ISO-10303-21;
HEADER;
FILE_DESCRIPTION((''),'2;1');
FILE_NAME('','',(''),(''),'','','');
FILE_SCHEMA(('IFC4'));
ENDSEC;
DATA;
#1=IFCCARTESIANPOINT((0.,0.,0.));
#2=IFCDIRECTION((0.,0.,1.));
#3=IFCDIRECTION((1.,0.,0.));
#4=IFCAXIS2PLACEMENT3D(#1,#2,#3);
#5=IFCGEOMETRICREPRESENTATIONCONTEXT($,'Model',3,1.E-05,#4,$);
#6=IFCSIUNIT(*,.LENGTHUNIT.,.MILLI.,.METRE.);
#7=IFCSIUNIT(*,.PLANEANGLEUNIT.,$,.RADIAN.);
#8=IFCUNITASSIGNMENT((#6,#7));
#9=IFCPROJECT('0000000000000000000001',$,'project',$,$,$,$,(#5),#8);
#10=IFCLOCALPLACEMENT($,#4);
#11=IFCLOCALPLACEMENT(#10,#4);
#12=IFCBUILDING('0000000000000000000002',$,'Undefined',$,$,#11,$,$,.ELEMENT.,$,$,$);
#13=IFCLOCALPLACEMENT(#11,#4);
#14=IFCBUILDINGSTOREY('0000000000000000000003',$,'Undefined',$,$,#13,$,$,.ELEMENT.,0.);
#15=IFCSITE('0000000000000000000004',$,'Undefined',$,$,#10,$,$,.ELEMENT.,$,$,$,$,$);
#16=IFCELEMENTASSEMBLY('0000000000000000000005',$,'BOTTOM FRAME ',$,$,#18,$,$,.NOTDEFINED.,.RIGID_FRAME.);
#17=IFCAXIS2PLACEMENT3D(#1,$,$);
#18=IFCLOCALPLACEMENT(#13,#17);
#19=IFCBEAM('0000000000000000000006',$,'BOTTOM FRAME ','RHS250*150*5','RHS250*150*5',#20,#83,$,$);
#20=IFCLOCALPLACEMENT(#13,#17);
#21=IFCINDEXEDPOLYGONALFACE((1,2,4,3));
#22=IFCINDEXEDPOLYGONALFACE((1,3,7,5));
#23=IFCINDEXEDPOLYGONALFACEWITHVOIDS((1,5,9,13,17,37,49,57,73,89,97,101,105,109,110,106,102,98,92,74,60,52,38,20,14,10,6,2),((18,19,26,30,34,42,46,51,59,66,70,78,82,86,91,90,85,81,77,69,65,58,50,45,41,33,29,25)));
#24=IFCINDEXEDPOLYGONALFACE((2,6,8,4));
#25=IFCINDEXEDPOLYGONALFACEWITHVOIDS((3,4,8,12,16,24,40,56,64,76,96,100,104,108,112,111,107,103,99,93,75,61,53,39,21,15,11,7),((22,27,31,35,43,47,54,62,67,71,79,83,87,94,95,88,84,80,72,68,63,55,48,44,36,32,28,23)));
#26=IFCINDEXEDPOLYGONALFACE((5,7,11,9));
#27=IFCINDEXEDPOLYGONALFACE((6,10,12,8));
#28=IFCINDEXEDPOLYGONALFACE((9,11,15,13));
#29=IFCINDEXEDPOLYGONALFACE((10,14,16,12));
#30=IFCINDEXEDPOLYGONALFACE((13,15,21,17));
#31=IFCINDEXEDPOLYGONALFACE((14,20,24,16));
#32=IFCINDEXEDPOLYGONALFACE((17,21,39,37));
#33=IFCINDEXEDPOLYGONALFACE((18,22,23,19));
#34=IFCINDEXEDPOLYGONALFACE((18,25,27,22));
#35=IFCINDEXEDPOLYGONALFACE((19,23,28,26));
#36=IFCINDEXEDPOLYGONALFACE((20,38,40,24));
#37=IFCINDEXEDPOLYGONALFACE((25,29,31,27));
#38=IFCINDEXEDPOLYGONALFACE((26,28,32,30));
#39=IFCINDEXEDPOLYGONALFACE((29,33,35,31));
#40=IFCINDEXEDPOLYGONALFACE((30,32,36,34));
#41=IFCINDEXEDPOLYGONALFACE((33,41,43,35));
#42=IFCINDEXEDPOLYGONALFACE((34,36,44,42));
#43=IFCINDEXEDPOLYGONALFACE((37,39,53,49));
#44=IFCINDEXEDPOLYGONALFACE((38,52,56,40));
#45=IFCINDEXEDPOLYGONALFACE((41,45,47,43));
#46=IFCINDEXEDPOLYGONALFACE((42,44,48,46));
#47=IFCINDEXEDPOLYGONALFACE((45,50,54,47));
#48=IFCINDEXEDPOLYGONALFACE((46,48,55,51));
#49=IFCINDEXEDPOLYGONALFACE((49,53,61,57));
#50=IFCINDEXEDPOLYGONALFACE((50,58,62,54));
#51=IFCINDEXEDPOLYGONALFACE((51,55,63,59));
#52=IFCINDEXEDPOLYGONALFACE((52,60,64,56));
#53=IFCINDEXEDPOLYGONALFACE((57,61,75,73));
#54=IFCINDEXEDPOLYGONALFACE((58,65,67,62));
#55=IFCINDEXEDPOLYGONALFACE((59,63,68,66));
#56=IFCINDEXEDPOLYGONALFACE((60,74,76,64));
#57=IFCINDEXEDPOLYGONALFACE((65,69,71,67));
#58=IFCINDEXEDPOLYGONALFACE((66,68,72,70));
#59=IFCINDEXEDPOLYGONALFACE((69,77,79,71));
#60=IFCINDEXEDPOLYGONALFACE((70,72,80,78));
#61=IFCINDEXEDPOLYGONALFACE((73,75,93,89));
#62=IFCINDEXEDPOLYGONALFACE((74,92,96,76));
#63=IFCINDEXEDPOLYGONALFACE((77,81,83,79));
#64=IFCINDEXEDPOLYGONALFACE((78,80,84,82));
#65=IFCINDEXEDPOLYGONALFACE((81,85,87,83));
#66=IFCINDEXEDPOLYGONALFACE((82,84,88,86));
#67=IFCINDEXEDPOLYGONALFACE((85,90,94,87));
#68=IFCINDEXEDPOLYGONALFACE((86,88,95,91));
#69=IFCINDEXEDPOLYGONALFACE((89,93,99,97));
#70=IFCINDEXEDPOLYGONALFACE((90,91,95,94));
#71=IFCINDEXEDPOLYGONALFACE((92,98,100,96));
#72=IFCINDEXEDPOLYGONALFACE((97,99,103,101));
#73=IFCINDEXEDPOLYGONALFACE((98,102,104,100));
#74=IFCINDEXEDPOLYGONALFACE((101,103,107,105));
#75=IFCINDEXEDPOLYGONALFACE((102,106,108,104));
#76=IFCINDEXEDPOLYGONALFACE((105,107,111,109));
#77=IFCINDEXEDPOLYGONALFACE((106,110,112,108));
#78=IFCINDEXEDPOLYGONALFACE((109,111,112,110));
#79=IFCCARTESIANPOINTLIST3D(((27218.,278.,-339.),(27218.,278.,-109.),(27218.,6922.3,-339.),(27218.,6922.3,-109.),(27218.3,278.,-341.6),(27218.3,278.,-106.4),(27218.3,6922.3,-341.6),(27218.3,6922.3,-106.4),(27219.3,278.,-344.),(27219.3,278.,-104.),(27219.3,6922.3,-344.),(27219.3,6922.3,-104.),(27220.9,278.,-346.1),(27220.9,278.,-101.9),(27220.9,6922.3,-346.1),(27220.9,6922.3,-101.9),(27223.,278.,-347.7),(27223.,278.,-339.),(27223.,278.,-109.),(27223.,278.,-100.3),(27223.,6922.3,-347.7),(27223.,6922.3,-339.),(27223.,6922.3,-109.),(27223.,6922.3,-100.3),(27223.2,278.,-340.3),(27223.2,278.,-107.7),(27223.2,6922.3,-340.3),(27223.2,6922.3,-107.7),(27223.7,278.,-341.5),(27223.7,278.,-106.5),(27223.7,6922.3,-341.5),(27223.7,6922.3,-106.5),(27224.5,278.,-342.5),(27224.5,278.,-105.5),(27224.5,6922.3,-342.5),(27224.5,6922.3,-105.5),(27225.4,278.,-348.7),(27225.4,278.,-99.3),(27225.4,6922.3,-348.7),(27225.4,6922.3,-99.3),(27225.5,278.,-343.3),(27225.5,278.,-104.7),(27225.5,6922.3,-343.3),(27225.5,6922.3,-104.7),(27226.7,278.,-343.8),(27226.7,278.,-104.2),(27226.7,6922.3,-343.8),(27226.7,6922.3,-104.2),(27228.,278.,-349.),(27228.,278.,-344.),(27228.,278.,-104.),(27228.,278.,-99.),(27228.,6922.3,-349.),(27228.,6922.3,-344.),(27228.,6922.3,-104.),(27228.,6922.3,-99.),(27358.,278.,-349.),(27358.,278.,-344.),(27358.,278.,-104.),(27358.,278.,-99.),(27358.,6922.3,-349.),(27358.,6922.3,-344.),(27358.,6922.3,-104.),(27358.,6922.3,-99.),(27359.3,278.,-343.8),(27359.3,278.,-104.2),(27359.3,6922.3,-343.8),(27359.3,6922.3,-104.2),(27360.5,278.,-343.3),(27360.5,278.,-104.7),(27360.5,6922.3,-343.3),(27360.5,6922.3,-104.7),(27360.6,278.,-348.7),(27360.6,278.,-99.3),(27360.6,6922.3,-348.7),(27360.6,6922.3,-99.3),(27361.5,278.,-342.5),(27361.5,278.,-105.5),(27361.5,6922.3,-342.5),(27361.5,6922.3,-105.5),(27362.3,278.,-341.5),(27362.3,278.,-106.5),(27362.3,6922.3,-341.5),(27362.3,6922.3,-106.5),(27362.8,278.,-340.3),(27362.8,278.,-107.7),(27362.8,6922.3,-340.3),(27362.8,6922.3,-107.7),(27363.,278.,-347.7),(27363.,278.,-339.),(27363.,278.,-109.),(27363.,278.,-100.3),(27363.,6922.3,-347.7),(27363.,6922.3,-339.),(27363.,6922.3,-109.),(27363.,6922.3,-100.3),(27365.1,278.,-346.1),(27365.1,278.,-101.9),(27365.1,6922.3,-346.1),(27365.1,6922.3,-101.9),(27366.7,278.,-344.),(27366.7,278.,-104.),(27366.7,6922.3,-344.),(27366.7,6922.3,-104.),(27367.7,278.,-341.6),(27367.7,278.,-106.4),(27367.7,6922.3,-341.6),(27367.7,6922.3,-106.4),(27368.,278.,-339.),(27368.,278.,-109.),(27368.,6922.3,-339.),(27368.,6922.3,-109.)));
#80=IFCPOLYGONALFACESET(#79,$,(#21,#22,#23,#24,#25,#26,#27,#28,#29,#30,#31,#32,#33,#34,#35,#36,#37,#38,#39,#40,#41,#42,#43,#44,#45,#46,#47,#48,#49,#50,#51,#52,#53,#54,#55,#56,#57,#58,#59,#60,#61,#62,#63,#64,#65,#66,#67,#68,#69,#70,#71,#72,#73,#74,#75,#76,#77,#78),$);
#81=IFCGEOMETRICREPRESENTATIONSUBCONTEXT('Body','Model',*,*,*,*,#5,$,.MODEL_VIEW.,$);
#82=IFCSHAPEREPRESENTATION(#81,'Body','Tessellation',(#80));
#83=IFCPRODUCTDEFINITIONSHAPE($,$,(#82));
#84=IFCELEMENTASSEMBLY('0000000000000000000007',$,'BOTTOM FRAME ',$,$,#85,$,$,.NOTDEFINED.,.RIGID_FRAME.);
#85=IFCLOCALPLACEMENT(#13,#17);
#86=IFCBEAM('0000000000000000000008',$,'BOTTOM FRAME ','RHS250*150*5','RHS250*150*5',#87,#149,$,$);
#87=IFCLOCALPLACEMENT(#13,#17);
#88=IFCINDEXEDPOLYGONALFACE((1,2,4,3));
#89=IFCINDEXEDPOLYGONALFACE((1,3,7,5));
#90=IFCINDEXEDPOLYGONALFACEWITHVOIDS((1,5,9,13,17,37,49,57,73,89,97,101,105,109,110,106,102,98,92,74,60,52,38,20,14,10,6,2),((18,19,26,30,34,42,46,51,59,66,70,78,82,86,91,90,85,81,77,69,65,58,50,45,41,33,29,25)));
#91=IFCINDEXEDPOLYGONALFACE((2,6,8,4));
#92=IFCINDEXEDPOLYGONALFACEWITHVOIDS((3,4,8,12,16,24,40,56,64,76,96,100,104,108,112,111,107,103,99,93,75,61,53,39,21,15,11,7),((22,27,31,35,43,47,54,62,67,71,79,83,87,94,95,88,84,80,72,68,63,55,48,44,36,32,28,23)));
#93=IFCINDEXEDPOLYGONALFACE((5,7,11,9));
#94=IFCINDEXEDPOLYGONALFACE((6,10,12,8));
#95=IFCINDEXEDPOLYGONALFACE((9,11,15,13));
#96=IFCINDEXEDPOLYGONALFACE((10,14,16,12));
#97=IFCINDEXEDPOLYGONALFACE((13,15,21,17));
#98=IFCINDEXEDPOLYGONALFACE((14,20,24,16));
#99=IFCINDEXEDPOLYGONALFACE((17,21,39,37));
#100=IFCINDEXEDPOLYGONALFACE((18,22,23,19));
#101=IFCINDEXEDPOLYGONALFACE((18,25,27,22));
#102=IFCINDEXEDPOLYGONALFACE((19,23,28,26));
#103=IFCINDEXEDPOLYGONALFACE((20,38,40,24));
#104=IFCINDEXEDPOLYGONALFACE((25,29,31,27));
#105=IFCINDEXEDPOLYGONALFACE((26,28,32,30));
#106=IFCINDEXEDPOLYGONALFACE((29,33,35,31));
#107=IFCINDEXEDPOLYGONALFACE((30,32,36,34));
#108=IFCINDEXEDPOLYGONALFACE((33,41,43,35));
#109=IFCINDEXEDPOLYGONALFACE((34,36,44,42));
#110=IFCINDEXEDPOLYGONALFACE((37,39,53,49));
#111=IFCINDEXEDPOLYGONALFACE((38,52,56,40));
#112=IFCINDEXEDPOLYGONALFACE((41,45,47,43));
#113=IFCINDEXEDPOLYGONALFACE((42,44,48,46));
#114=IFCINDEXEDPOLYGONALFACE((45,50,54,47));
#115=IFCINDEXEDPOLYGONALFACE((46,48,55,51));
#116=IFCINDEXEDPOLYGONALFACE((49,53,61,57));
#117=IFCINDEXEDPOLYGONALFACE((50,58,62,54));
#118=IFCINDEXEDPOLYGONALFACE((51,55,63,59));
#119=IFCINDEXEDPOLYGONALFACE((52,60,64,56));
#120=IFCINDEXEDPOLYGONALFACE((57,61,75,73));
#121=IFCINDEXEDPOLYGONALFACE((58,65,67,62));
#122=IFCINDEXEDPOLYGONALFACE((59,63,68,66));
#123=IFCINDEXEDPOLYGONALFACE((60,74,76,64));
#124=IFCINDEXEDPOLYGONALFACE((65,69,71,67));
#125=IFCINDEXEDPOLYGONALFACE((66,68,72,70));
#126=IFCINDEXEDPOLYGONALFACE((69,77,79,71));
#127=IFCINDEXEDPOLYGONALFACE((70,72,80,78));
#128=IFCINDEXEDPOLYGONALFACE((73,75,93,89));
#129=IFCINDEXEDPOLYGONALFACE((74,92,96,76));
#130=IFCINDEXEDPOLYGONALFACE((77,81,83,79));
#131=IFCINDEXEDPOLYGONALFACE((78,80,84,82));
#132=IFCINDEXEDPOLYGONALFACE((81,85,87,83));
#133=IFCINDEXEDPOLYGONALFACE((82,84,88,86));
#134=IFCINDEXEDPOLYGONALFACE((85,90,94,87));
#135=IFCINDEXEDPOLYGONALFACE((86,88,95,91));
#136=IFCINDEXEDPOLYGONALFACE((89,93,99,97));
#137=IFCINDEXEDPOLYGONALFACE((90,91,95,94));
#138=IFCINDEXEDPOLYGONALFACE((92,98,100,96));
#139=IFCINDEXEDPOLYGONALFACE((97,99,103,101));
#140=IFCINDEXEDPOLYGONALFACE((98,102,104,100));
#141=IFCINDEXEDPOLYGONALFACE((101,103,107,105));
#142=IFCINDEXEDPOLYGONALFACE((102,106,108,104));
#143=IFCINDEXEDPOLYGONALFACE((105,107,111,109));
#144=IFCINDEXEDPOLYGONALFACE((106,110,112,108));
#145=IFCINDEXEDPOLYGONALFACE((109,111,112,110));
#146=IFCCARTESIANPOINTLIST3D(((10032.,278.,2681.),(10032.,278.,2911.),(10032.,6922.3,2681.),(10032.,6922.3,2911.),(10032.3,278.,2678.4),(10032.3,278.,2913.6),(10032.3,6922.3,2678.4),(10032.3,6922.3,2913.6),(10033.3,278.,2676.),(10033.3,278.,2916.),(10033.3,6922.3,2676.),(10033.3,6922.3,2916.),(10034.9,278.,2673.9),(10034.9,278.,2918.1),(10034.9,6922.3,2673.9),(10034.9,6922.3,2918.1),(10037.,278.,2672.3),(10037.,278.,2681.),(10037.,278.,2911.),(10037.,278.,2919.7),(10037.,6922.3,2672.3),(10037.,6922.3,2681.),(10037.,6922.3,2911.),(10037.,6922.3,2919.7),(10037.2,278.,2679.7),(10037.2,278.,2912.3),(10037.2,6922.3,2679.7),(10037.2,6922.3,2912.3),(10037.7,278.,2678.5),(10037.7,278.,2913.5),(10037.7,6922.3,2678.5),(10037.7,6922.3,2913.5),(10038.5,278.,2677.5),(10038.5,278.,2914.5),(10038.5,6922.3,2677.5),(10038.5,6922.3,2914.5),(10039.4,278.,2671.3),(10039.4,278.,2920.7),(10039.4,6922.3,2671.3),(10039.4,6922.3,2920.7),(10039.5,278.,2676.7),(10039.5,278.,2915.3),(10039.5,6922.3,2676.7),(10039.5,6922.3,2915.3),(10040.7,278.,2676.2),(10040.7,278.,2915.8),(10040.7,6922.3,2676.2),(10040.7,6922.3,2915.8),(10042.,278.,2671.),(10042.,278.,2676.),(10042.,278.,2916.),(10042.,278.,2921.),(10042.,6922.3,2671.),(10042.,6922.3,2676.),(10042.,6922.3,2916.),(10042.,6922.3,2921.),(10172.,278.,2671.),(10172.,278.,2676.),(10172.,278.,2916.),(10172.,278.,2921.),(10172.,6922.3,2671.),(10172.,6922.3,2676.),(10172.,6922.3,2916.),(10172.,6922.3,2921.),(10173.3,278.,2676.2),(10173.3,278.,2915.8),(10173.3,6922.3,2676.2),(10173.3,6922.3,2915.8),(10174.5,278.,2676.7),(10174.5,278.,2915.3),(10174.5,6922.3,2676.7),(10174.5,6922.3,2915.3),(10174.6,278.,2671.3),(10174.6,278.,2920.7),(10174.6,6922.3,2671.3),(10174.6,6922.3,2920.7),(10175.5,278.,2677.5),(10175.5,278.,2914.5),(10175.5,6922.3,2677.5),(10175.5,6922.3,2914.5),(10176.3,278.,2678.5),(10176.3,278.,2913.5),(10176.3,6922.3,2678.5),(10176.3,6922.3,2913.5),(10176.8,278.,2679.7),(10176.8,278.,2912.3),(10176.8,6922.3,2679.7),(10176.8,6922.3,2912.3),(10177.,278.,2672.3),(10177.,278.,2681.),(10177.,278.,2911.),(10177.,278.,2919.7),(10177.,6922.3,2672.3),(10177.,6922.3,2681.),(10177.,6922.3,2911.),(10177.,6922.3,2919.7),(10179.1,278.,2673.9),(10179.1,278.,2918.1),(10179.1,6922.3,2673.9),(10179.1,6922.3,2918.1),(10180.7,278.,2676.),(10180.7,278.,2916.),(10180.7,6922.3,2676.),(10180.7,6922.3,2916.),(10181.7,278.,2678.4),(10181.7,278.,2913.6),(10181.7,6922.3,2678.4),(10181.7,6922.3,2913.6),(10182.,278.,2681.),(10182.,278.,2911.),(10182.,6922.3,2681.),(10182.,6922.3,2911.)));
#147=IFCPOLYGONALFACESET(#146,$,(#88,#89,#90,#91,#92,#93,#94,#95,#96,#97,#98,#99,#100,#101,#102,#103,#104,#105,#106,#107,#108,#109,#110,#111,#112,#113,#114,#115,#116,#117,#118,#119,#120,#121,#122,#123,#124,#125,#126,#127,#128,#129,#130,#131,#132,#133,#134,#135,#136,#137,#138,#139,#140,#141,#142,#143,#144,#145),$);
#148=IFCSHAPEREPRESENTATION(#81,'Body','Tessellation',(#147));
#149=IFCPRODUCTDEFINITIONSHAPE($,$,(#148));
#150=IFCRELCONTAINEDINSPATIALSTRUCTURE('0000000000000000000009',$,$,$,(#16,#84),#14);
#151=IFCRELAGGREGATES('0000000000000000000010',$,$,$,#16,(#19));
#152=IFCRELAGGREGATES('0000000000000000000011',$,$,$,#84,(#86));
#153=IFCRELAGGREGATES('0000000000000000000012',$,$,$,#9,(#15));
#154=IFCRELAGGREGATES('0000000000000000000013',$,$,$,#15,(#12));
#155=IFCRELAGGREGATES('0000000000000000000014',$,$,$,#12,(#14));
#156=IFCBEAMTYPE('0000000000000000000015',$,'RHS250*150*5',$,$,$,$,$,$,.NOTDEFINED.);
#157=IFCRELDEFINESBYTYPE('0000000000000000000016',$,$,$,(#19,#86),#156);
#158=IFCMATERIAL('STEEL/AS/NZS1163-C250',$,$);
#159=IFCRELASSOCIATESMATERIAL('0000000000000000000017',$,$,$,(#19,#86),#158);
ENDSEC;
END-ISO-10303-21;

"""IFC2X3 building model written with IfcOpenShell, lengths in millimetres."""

from ifc_helpers import new_model, si_unit, frame, origin_with_axes, origin_2d_with_axis, place, context, subcontext, project, spatial, hollow_rectangle, extrude, material, type_object, element, aggregate, save


model = new_model("IFC2X3")

# Units and contexts
model_context = context("Model", 3, precision=1e-05, world=origin_with_axes())
body_context = subcontext(model_context, "Body", "Model", "MODEL_VIEW")
ifc_project = project(units=[si_unit("LENGTHUNIT", "METRE", prefix="MILLI"), si_unit("PLANEANGLEUNIT", "RADIAN")], contexts=[model_context])

# Site, building, storey
site_placement = place(None, origin_with_axes())
site = spatial("IfcSite", under=ifc_project, at=site_placement, Name="Undefined", CompositionType="ELEMENT")
building_placement = place(site_placement, origin_with_axes())
building = spatial("IfcBuilding", under=site, at=building_placement, Name="Undefined", CompositionType="ELEMENT")
storey_placement = place(building_placement, origin_with_axes())
storey = spatial("IfcBuildingStorey", under=building, at=storey_placement, Name="Undefined", CompositionType="ELEMENT", Elevation=0.0)

# Shared definitions
ifc_material_1 = material(Name="STEEL/AS/NZS1163-C250")

# Element assemblies, beams
assembly_1_placement = place(storey_placement, origin_with_axes())
assembly_1 = element("IfcElementAssembly", 1, at=assembly_1_placement, inside=storey, Name="BOTTOM FRAME ", AssemblyPlace="NOTDEFINED", PredefinedType="RIGID_FRAME")
beam_type_1 = type_object("IfcBeamType", Name="RHS250*150*5", PredefinedType="NOTDEFINED")
beam_1_placement = place(assembly_1_placement, frame((27293.0, 6922.3, -224.0), z_axis=(0.0, 0.0, 1.0), x_axis=(0.0, -1.0, 0.0)))
beam_1 = element("IfcBeam", 2, at=beam_1_placement, type_object=beam_type_1, material=ifc_material_1, Name="BOTTOM FRAME ", Description="RHS250*150*5", ObjectType="RHS250*150*5", context=body_context, shape_type="SweptSolid", body=[
    extrude(hollow_rectangle(XDim=150.0, YDim=250.0, WallThickness=5.0, InnerFilletRadius=5.0, OuterFilletRadius=10.0, at=origin_2d_with_axis()), frame((6644.3, 0.0, 0.0), z_axis=(-1.0, 0.0, 0.0), x_axis=(0.0, -1.0, 0.0)), (0.0, 0.0, 1.0), 6644.3),
])
aggregate(assembly_1, [beam_1])
assembly_2_placement = place(storey_placement, origin_with_axes())
assembly_2 = element("IfcElementAssembly", 3, at=assembly_2_placement, inside=storey, Name="BOTTOM FRAME ", AssemblyPlace="NOTDEFINED", PredefinedType="RIGID_FRAME")
beam_2_placement = place(assembly_2_placement, frame((10107.0, 6922.3, 2796.0), z_axis=(0.0, 0.0, 1.0), x_axis=(0.0, -1.0, 0.0)))
beam_2 = element("IfcBeam", 4, at=beam_2_placement, type_object=beam_type_1, material=ifc_material_1, Name="BOTTOM FRAME ", Description="RHS250*150*5", ObjectType="RHS250*150*5", context=body_context, shape_type="SweptSolid", body=[
    extrude(hollow_rectangle(XDim=150.0, YDim=250.0, WallThickness=5.0, InnerFilletRadius=5.0, OuterFilletRadius=10.0, at=origin_2d_with_axis()), frame((6644.3, 0.0, 0.0), z_axis=(-1.0, 0.0, 0.0), x_axis=(0.0, -1.0, 0.0)), (0.0, 0.0, 1.0), 6644.3),
])
aggregate(assembly_2, [beam_2])

save(model, "model.ifc")
